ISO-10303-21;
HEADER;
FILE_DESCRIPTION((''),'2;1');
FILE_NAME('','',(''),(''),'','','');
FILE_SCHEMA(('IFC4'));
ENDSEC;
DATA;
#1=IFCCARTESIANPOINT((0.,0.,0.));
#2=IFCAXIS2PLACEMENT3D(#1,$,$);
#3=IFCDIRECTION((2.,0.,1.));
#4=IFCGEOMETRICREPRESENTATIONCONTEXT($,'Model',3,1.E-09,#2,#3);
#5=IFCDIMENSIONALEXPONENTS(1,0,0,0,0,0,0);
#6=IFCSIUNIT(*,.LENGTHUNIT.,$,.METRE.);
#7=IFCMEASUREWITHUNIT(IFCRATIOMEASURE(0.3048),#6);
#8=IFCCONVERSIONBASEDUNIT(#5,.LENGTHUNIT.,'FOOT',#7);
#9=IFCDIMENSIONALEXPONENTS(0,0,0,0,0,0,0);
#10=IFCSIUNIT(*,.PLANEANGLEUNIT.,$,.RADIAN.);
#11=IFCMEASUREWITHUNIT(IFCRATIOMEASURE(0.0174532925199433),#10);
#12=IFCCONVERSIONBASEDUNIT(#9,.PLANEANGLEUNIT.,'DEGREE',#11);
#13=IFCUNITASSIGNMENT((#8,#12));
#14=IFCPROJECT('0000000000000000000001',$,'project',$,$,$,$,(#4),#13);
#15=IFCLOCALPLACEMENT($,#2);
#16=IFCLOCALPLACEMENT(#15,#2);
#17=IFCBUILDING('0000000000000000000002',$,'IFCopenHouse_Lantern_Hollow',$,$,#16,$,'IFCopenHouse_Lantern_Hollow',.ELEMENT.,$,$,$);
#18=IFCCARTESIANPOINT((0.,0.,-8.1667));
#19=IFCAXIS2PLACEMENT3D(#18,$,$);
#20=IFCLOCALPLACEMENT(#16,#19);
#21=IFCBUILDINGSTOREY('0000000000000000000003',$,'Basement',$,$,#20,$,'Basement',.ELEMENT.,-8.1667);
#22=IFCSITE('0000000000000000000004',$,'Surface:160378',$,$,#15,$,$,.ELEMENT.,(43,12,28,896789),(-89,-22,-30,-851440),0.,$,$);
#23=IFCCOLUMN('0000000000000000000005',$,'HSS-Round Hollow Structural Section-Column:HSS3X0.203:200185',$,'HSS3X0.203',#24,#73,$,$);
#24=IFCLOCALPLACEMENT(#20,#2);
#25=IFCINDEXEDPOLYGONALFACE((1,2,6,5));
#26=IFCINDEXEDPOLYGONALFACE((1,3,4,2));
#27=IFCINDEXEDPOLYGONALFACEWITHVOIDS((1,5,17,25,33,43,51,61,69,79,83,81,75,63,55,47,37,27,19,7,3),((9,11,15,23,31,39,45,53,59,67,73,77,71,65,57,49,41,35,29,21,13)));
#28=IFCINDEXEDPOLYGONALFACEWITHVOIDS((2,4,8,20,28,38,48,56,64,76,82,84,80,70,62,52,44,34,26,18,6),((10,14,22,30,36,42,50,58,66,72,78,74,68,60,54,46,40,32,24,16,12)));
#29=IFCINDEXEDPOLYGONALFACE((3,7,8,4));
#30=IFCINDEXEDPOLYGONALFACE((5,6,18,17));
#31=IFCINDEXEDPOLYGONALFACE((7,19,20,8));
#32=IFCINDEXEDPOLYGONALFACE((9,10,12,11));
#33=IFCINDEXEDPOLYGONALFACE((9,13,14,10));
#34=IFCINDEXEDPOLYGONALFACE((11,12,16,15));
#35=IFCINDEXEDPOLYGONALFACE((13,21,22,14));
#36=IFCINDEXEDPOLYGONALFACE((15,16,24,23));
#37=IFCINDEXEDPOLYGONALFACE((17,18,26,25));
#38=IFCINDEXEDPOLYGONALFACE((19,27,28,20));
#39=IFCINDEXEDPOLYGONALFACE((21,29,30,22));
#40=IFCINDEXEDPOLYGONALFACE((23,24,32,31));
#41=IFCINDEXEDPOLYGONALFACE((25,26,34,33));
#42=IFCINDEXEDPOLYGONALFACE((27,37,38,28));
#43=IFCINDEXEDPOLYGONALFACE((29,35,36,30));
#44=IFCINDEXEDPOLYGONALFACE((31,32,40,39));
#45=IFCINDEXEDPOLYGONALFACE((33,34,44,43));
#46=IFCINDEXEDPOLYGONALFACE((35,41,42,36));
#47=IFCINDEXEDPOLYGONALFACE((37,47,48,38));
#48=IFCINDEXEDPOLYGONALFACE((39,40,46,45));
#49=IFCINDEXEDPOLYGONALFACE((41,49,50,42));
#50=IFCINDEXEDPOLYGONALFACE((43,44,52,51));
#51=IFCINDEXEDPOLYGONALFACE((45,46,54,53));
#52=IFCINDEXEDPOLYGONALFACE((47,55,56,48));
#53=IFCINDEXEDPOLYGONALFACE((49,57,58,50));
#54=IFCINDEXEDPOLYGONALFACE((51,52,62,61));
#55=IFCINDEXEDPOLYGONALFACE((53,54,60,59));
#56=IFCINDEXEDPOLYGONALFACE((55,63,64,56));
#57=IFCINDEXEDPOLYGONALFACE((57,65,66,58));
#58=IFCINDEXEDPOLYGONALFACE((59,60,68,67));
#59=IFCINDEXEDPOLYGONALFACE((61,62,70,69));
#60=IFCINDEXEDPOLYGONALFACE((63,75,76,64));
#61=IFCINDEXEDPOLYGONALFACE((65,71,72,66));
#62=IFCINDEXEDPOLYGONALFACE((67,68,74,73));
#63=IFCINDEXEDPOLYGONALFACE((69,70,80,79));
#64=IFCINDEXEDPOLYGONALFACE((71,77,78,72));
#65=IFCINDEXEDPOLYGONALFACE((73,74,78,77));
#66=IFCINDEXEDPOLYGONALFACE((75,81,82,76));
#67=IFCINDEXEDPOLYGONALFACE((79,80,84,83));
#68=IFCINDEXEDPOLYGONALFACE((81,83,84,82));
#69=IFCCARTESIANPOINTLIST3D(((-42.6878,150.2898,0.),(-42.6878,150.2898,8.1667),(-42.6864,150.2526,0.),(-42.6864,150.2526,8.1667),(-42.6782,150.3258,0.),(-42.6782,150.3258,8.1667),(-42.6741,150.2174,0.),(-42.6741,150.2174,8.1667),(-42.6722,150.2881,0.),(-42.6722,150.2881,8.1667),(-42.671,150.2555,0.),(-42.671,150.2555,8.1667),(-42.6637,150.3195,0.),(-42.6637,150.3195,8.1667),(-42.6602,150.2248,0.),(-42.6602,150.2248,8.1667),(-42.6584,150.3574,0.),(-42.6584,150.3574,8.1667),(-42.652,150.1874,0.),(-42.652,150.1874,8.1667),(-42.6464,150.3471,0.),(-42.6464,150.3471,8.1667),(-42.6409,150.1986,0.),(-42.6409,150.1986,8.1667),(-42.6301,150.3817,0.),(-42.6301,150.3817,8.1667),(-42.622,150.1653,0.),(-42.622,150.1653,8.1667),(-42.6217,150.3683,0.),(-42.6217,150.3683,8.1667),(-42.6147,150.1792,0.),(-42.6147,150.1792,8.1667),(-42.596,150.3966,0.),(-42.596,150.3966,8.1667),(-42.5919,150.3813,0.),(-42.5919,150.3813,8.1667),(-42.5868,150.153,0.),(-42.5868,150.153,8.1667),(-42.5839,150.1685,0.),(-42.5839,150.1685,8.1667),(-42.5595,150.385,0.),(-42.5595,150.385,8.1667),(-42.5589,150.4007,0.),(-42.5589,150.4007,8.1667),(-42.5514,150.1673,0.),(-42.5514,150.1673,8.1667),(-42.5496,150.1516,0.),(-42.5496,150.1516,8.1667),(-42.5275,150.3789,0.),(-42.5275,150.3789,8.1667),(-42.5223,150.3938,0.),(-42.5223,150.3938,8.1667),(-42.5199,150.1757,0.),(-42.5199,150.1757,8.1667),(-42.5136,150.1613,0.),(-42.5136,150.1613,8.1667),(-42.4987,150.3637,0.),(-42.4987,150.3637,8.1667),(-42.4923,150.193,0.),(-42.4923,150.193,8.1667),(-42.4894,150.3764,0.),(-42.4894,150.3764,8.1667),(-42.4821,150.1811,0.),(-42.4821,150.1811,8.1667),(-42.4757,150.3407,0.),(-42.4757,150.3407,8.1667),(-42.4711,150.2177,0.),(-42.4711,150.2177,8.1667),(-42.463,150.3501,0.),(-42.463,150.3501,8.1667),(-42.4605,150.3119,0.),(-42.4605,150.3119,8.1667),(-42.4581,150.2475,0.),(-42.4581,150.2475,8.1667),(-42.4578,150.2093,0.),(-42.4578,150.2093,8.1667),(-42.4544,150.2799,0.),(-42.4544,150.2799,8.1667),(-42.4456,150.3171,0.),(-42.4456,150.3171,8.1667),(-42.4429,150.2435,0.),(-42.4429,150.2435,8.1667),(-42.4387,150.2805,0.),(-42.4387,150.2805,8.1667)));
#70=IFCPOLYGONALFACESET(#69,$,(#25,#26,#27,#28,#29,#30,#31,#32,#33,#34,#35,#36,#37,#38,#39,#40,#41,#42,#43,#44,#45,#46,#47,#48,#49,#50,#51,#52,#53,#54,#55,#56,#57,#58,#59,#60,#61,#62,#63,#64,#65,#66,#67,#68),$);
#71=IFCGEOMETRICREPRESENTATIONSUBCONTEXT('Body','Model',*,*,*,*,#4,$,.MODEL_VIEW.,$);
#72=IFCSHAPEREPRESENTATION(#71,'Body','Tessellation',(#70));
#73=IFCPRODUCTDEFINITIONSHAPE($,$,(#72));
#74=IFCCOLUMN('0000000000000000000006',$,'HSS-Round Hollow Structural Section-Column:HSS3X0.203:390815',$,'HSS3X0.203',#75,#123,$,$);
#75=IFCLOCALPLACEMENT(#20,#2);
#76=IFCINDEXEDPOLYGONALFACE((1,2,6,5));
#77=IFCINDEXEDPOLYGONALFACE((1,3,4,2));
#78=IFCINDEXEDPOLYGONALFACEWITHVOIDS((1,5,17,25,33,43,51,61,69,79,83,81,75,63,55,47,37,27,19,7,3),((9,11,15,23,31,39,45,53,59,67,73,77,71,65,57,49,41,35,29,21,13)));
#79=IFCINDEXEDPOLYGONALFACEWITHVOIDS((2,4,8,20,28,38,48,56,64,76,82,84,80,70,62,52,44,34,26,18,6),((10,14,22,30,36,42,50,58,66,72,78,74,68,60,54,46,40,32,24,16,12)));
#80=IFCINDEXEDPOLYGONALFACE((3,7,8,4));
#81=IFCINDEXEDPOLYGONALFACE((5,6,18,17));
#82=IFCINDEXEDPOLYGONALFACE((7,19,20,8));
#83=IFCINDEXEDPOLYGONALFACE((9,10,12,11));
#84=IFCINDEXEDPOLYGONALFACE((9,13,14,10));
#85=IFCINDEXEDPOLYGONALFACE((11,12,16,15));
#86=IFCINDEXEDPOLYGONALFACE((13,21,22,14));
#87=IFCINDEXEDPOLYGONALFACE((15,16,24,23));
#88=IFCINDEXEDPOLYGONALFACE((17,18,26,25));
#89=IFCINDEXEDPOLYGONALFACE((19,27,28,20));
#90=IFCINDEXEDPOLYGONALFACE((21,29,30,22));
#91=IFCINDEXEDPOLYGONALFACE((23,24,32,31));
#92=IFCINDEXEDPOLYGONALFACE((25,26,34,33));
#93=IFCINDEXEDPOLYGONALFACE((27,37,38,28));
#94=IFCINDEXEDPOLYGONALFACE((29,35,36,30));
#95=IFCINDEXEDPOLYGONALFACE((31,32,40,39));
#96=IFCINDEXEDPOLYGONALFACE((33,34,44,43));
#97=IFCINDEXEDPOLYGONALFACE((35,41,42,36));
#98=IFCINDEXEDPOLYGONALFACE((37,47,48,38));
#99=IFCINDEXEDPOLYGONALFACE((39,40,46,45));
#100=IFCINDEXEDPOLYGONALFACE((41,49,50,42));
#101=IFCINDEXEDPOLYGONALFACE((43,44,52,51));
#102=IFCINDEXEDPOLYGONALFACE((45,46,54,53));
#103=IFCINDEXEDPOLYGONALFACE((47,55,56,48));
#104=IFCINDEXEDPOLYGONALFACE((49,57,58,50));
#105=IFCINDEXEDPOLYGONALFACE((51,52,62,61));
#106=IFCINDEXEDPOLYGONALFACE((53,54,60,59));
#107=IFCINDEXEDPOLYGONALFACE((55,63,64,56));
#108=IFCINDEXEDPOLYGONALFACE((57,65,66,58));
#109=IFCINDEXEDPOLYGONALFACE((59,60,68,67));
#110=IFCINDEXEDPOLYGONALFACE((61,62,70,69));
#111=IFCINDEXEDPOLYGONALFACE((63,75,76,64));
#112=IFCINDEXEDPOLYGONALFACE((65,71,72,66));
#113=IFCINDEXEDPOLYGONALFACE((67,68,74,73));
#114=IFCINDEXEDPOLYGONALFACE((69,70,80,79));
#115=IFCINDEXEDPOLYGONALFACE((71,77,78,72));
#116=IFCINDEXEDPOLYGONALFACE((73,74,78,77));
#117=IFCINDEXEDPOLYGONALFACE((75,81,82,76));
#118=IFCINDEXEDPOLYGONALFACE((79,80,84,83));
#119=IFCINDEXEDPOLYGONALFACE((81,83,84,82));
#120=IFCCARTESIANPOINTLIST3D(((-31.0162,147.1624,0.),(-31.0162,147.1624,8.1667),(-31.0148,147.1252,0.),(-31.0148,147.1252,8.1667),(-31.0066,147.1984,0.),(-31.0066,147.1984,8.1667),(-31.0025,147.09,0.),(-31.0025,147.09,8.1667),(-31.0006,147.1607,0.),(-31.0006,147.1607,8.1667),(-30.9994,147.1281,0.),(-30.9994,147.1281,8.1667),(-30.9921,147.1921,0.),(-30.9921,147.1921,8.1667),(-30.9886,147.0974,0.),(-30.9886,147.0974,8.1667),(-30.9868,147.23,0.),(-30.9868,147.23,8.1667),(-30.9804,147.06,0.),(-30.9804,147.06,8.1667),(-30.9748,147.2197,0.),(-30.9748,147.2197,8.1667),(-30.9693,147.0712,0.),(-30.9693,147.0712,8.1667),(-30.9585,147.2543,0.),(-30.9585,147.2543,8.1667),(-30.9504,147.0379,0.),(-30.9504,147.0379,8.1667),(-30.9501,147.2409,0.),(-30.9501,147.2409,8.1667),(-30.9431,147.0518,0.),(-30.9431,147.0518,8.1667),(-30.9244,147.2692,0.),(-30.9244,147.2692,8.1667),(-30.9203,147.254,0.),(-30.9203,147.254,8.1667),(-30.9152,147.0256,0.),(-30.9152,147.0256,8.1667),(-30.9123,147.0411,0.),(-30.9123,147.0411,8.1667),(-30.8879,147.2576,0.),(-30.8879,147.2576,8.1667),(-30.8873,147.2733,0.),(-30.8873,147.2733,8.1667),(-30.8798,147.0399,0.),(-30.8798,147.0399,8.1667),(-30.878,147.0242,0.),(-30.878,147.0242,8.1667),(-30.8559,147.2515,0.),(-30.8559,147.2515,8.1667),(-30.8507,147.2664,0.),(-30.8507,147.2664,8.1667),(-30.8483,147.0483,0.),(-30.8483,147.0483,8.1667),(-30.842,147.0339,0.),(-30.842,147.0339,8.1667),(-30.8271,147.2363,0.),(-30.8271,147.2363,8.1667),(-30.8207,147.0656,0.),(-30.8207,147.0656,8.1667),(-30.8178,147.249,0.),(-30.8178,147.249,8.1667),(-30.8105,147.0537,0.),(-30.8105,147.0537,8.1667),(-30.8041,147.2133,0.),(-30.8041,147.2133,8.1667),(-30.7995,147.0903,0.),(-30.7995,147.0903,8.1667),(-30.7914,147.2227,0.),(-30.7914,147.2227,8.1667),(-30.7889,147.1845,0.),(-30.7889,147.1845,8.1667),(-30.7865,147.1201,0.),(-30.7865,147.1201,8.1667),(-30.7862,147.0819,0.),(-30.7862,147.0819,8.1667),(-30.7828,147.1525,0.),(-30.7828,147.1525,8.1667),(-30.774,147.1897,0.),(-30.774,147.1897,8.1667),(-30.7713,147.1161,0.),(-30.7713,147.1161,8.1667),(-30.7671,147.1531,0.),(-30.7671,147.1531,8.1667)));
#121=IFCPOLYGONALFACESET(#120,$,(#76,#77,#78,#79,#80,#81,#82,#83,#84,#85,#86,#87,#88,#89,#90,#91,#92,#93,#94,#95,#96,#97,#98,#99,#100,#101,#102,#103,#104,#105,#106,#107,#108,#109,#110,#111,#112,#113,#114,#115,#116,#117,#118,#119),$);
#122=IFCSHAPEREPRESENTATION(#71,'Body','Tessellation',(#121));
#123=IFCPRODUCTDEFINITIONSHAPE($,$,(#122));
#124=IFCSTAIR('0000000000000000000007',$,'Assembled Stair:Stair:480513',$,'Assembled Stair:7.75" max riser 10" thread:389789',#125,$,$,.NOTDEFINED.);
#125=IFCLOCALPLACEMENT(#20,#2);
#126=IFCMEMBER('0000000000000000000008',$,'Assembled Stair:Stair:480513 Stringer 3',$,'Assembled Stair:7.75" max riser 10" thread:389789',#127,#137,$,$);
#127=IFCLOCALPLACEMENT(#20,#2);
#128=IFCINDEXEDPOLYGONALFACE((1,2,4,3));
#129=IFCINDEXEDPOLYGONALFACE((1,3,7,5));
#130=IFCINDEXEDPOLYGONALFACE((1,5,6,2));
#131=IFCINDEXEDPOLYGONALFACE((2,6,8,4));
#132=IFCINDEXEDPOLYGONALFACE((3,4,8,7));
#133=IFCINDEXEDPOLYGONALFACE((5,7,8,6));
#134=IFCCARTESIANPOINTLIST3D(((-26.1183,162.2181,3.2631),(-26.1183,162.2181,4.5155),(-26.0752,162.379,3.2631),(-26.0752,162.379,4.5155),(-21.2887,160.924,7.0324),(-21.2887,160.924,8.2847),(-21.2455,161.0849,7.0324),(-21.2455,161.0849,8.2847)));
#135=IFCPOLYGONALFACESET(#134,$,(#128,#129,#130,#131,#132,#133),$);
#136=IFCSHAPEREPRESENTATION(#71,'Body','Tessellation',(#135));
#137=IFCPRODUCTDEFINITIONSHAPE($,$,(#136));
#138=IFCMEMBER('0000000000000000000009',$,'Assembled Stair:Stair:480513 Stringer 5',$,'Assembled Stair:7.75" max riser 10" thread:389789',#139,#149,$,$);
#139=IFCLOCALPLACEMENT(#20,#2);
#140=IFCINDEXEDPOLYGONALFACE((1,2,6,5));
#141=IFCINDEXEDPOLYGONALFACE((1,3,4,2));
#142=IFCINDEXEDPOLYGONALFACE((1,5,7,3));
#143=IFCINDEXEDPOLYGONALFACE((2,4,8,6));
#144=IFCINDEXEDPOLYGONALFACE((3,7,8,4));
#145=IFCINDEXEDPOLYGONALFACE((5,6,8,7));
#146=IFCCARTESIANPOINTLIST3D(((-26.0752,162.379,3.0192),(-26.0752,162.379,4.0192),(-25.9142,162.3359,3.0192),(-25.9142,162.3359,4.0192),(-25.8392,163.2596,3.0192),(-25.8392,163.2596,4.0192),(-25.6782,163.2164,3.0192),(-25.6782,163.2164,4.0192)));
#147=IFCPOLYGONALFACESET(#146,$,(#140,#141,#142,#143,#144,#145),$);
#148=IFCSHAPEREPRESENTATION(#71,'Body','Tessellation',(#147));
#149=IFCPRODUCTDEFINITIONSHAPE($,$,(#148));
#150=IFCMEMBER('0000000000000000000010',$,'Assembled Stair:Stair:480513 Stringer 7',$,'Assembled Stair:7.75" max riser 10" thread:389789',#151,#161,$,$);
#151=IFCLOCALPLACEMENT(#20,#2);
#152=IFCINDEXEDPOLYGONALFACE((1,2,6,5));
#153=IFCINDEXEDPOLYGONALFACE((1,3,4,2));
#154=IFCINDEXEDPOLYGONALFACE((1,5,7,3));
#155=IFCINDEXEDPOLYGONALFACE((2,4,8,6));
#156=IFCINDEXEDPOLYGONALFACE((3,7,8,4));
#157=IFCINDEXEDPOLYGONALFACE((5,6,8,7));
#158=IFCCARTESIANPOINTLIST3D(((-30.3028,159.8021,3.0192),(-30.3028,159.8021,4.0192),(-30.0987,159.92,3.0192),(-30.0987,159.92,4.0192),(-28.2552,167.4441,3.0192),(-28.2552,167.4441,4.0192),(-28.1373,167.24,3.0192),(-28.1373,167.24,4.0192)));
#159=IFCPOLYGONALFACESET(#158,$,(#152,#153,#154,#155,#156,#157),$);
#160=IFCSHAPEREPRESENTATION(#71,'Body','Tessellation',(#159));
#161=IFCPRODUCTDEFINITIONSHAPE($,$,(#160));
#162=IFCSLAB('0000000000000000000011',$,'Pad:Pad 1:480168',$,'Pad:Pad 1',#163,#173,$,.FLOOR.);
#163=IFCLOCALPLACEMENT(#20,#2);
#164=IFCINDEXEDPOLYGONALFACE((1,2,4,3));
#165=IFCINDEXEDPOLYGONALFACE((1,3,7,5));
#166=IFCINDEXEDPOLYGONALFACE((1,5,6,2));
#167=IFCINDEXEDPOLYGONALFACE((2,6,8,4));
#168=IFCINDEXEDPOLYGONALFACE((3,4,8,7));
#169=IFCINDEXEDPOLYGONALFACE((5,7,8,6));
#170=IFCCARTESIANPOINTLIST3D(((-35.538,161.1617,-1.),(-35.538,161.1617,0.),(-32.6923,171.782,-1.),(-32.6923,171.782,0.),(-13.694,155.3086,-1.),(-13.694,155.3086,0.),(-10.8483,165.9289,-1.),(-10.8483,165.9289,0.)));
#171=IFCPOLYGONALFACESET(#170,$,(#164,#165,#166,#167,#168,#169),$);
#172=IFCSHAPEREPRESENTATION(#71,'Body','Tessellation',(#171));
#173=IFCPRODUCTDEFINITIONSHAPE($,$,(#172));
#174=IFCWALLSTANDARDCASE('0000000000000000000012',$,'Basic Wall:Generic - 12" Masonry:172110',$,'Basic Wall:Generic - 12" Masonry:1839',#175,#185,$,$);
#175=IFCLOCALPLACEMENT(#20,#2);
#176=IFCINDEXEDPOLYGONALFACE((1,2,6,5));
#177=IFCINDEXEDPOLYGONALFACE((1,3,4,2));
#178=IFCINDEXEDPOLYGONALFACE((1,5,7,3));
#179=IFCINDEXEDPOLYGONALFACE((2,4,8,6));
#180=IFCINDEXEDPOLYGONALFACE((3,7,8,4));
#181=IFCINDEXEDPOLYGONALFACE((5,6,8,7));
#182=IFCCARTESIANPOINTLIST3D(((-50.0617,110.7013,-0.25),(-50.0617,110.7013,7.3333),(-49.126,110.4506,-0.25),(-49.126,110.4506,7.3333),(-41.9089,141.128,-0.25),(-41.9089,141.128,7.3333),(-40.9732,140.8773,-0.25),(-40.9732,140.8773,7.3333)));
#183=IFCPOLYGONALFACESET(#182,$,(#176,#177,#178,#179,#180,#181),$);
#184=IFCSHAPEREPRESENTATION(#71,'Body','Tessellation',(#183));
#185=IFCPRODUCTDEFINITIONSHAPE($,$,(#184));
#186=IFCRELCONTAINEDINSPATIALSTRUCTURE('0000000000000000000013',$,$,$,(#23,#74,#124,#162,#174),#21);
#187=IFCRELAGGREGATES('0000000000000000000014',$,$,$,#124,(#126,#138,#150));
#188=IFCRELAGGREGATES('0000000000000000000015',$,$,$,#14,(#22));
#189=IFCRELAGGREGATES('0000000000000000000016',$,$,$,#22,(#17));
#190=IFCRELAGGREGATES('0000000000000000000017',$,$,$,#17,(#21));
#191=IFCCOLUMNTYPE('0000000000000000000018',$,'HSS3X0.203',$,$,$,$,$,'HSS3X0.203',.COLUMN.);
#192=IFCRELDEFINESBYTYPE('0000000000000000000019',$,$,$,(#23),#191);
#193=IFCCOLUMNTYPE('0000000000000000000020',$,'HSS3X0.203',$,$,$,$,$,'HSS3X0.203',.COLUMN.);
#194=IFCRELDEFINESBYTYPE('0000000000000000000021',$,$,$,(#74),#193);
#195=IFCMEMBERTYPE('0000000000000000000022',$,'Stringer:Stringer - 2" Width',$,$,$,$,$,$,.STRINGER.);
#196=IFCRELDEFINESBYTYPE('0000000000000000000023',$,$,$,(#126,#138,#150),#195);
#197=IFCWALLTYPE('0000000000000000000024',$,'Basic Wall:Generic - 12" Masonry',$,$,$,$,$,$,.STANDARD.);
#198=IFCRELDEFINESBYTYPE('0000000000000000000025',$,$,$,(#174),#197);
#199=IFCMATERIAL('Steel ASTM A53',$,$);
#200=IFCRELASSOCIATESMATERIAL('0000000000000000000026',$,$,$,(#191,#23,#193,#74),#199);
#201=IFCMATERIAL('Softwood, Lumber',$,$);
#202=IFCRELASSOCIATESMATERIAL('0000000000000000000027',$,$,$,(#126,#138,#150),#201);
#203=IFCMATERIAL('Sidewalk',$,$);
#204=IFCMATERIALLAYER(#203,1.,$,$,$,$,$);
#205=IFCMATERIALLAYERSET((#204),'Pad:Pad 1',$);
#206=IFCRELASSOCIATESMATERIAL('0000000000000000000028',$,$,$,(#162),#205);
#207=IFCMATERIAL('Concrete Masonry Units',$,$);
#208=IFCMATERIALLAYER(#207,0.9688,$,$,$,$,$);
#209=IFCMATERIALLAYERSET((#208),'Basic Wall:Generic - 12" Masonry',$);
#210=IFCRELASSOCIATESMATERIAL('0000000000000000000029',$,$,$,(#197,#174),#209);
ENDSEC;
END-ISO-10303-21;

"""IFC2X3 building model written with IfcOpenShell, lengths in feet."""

from ifc_helpers import new_model, entity, si_unit, converted_unit, direction, frame, frame_2d, origin, origin_2d_with_axis, place, context, subcontext, project, spatial, polyline, rectangle, hollow_circle, outline, extrude, source, transform, mapped, material, layer, layer_set, layer_usage, type_object, type_shapes, element, aggregate, save


model = new_model("IFC2X3")

# Units and contexts
model_context = context("Model", 3, precision=1e-09, world=origin(), true_north=direction((2.0, 0.0, 1.0)))
body_context = subcontext(model_context, "Body", "Model", "MODEL_VIEW")
ifc_project = project(units=[converted_unit("LENGTHUNIT", "FOOT", entity("IfcRatioMeasure", 0.3048), si_unit("LENGTHUNIT", "METRE"), dimensions=[1, 0, 0, 0, 0, 0, 0]), converted_unit("PLANEANGLEUNIT", "DEGREE", entity("IfcRatioMeasure", 0.0174532925199433), si_unit("PLANEANGLEUNIT", "RADIAN"), dimensions=[0, 0, 0, 0, 0, 0, 0])], contexts=[model_context])

# Site, building, storey
site_placement = place(None, origin())
site = spatial("IfcSite", under=ifc_project, at=site_placement, Name="Surface:160378", CompositionType="ELEMENT", RefLatitude=(43, 12, 28, 896789), RefLongitude=(-89, -22, -30, -851440), RefElevation=0.0)
building_placement = place(site_placement, origin())
building = spatial("IfcBuilding", under=site, at=building_placement, Name="IFCopenHouse_Lantern_Hollow", LongName="IFCopenHouse_Lantern_Hollow", CompositionType="ELEMENT")
storey_placement = place(building_placement, frame((0.0, 0.0, -8.1667)))
storey = spatial("IfcBuildingStorey", under=building, at=storey_placement, Name="Basement", LongName="Basement", CompositionType="ELEMENT", Elevation=-8.1667)

# Columns
ifc_material_1 = material(Name="Steel ASTM A53")
column_type_1 = type_object("IfcColumnType", Name="HSS3X0.203", ElementType="HSS3X0.203", PredefinedType="COLUMN", material=ifc_material_1)
shared_shape_1 = source(origin(), body_context, "Body", "SweptSolid", [
    extrude(hollow_circle(Radius=0.125, WallThickness=0.0157, at=origin_2d_with_axis()), frame((0.128, 0.1301, 0.0), z_axis=(0.0, 0.0, 1.0), x_axis=(0.965926, -0.258819, 0.0)), (0.0, 0.0, 1.0), 8.1667),
])
type_shapes(column_type_1, [shared_shape_1])
column_1_placement = place(storey_placement, frame((-42.6916, 150.1457, 0.0)))
element("IfcColumn", 1, at=column_1_placement, inside=storey, type_object=column_type_1, material=ifc_material_1, Name="HSS-Round Hollow Structural Section-Column:HSS3X0.203:200185", ObjectType="HSS3X0.203", context=body_context, shape_type="MappedRepresentation", body=[
    mapped(shared_shape_1, transform((0.0, 0.0, 0.0), scale=1.0)),
])
column_type_2 = type_object("IfcColumnType", Name="HSS3X0.203", ElementType="HSS3X0.203", PredefinedType="COLUMN", material=ifc_material_1)
shared_shape_2 = source(origin(), body_context, "Body", "SweptSolid", [
    extrude(hollow_circle(Radius=0.125, WallThickness=0.0157, at=origin_2d_with_axis()), frame((0.128, 0.1301, 0.0), z_axis=(0.0, 0.0, 1.0), x_axis=(0.965926, -0.258819, 0.0)), (0.0, 0.0, 1.0), 8.1667),
])
type_shapes(column_type_2, [shared_shape_2])
column_2_placement = place(storey_placement, frame((-31.02, 147.0183, 0.0)))
element("IfcColumn", 2, at=column_2_placement, inside=storey, type_object=column_type_2, material=ifc_material_1, Name="HSS-Round Hollow Structural Section-Column:HSS3X0.203:390815", ObjectType="HSS3X0.203", context=body_context, shape_type="MappedRepresentation", body=[
    mapped(shared_shape_2, transform((0.0, 0.0, 0.0), scale=1.0)),
])

# Shared definitions
ifc_material_2 = material(Name="Softwood, Lumber")
member_type = type_object("IfcMemberType", Name="Stringer:Stringer - 2\" Width", PredefinedType="STRINGER")

# Stair, members
stair_1_placement = place(storey_placement, origin())
stair_1 = element("IfcStair", 3, at=stair_1_placement, inside=storey, Name="Assembled Stair:Stair:480513", ObjectType="Assembled Stair:7.75\" max riser 10\" thread:389789", ShapeType="NOTDEFINED")
member_1_placement = place(stair_1_placement, frame((-26.1183, 160.924, 3.2631)))
member_1 = element("IfcMember", 4, at=member_1_placement, type_object=member_type, material=ifc_material_2, Name="Assembled Stair:Stair:480513 Stringer 3", ObjectType="Assembled Stair:7.75\" max riser 10\" thread:389789", context=body_context, shape_type="SweptSolid", body=[
    extrude(outline(polyline([(-2.7539, -0.5), (3.5077, -0.5), (2.7539, 0.5), (-3.5077, 0.5), (-2.7539, -0.5)])), frame((2.4148, 0.647, 2.5108), z_axis=(0.258819, 0.965926, 0.0), x_axis=(0.771314, -0.206673, 0.601964)), (0.0, 0.0, 1.0), 0.1667),
])
member_2_placement = place(stair_1_placement, frame((-26.0752, 162.3359, 3.0192)))
member_2 = element("IfcMember", 5, at=member_2_placement, type_object=member_type, material=ifc_material_2, Name="Assembled Stair:Stair:480513 Stringer 5", ObjectType="Assembled Stair:7.75\" max riser 10\" thread:389789", context=body_context, shape_type="SweptSolid", body=[
    extrude(rectangle(XDim=0.9116, YDim=0.1667, at=frame_2d((0.0, 0.0), x_axis=(1.0, 0.0))), frame((0.1985, 0.4618, 0.0), z_axis=(0.0, 0.0, 1.0), x_axis=(0.258819, 0.965926, 0.0)), (0.0, 0.0, 1.0), 1.0),
])
member_3_placement = place(stair_1_placement, frame((-30.3028, 159.8021, 3.0192)))
member_3 = element("IfcMember", 6, at=member_3_placement, type_object=member_type, material=ifc_material_2, Name="Assembled Stair:Stair:480513 Stringer 7", ObjectType="Assembled Stair:7.75\" max riser 10\" thread:389789", context=body_context, shape_type="SweptSolid", body=[
    extrude(outline(polyline([(-3.9558, -0.0833), (3.9558, -0.0833), (3.7891, 0.0833), (-3.7891, 0.0833), (-3.9558, -0.0833)])), frame((1.1043, 3.7994, 0.0), z_axis=(0.0, 0.0, 1.0), x_axis=(-0.258819, -0.965926, 0.0)), (0.0, 0.0, 1.0), 1.0),
])

# Slab
ifc_material_3 = material(Name="Sidewalk")
ifc_layer_1 = layer(ifc_material_3, 1.0)
ifc_layer_set_1 = layer_set([ifc_layer_1], Name="Pad:Pad 1")
ifc_layer_usage_1 = layer_usage(ifc_layer_set_1, "AXIS3", "NEGATIVE", 0.0)
slab_placement = place(storey_placement, frame((-35.538, 155.3086, -1.0)))
element("IfcSlab", 7, at=slab_placement, inside=storey, material=ifc_layer_usage_1, Name="Pad:Pad 1:480168", ObjectType="Pad:Pad 1", PredefinedType="FLOOR", context=body_context, shape_type="SweptSolid", body=[
    extrude(rectangle(XDim=22.6146, YDim=10.9949, at=frame_2d((0.0, 0.0), x_axis=(0.965926, 0.258819))), frame((12.3449, 8.2367, 1.0), z_axis=(0.0, 0.0, -1.0), x_axis=(-1.0, 0.0, 0.0)), (0.0, 0.0, 1.0), 1.0),
])

# Wall
ifc_material_4 = material(Name="Concrete Masonry Units")
ifc_layer_2 = layer(ifc_material_4, 0.9688)
ifc_layer_set_2 = layer_set([ifc_layer_2], Name="Basic Wall:Generic - 12\" Masonry")
ifc_layer_usage_2 = layer_usage(ifc_layer_set_2, "AXIS2", "NEGATIVE", 0.4844)
wall_type_1 = type_object("IfcWallType", Name="Basic Wall:Generic - 12\" Masonry", PredefinedType="STANDARD", material=ifc_layer_set_2)
wall_1_placement = place(storey_placement, frame((-41.4411, 141.0026, -0.25), z_axis=(0.0, 0.0, 1.0), x_axis=(-0.258819, -0.965926, 0.0)))
element("IfcWallStandardCase", 8, at=wall_1_placement, inside=storey, type_object=wall_type_1, material=ifc_layer_usage_2, Name="Basic Wall:Generic - 12\" Masonry:172110", ObjectType="Basic Wall:Generic - 12\" Masonry:1839", context=body_context, shape_type="SweptSolid", body=[
    extrude(rectangle(XDim=31.5, YDim=0.9688, at=frame_2d((15.75, 0.0), x_axis=(-1.0, 0.0))), origin(), (0.0, 0.0, 1.0), 7.5833),
])

aggregate(stair_1, [member_1, member_2, member_3])

save(model, "model.ifc")
